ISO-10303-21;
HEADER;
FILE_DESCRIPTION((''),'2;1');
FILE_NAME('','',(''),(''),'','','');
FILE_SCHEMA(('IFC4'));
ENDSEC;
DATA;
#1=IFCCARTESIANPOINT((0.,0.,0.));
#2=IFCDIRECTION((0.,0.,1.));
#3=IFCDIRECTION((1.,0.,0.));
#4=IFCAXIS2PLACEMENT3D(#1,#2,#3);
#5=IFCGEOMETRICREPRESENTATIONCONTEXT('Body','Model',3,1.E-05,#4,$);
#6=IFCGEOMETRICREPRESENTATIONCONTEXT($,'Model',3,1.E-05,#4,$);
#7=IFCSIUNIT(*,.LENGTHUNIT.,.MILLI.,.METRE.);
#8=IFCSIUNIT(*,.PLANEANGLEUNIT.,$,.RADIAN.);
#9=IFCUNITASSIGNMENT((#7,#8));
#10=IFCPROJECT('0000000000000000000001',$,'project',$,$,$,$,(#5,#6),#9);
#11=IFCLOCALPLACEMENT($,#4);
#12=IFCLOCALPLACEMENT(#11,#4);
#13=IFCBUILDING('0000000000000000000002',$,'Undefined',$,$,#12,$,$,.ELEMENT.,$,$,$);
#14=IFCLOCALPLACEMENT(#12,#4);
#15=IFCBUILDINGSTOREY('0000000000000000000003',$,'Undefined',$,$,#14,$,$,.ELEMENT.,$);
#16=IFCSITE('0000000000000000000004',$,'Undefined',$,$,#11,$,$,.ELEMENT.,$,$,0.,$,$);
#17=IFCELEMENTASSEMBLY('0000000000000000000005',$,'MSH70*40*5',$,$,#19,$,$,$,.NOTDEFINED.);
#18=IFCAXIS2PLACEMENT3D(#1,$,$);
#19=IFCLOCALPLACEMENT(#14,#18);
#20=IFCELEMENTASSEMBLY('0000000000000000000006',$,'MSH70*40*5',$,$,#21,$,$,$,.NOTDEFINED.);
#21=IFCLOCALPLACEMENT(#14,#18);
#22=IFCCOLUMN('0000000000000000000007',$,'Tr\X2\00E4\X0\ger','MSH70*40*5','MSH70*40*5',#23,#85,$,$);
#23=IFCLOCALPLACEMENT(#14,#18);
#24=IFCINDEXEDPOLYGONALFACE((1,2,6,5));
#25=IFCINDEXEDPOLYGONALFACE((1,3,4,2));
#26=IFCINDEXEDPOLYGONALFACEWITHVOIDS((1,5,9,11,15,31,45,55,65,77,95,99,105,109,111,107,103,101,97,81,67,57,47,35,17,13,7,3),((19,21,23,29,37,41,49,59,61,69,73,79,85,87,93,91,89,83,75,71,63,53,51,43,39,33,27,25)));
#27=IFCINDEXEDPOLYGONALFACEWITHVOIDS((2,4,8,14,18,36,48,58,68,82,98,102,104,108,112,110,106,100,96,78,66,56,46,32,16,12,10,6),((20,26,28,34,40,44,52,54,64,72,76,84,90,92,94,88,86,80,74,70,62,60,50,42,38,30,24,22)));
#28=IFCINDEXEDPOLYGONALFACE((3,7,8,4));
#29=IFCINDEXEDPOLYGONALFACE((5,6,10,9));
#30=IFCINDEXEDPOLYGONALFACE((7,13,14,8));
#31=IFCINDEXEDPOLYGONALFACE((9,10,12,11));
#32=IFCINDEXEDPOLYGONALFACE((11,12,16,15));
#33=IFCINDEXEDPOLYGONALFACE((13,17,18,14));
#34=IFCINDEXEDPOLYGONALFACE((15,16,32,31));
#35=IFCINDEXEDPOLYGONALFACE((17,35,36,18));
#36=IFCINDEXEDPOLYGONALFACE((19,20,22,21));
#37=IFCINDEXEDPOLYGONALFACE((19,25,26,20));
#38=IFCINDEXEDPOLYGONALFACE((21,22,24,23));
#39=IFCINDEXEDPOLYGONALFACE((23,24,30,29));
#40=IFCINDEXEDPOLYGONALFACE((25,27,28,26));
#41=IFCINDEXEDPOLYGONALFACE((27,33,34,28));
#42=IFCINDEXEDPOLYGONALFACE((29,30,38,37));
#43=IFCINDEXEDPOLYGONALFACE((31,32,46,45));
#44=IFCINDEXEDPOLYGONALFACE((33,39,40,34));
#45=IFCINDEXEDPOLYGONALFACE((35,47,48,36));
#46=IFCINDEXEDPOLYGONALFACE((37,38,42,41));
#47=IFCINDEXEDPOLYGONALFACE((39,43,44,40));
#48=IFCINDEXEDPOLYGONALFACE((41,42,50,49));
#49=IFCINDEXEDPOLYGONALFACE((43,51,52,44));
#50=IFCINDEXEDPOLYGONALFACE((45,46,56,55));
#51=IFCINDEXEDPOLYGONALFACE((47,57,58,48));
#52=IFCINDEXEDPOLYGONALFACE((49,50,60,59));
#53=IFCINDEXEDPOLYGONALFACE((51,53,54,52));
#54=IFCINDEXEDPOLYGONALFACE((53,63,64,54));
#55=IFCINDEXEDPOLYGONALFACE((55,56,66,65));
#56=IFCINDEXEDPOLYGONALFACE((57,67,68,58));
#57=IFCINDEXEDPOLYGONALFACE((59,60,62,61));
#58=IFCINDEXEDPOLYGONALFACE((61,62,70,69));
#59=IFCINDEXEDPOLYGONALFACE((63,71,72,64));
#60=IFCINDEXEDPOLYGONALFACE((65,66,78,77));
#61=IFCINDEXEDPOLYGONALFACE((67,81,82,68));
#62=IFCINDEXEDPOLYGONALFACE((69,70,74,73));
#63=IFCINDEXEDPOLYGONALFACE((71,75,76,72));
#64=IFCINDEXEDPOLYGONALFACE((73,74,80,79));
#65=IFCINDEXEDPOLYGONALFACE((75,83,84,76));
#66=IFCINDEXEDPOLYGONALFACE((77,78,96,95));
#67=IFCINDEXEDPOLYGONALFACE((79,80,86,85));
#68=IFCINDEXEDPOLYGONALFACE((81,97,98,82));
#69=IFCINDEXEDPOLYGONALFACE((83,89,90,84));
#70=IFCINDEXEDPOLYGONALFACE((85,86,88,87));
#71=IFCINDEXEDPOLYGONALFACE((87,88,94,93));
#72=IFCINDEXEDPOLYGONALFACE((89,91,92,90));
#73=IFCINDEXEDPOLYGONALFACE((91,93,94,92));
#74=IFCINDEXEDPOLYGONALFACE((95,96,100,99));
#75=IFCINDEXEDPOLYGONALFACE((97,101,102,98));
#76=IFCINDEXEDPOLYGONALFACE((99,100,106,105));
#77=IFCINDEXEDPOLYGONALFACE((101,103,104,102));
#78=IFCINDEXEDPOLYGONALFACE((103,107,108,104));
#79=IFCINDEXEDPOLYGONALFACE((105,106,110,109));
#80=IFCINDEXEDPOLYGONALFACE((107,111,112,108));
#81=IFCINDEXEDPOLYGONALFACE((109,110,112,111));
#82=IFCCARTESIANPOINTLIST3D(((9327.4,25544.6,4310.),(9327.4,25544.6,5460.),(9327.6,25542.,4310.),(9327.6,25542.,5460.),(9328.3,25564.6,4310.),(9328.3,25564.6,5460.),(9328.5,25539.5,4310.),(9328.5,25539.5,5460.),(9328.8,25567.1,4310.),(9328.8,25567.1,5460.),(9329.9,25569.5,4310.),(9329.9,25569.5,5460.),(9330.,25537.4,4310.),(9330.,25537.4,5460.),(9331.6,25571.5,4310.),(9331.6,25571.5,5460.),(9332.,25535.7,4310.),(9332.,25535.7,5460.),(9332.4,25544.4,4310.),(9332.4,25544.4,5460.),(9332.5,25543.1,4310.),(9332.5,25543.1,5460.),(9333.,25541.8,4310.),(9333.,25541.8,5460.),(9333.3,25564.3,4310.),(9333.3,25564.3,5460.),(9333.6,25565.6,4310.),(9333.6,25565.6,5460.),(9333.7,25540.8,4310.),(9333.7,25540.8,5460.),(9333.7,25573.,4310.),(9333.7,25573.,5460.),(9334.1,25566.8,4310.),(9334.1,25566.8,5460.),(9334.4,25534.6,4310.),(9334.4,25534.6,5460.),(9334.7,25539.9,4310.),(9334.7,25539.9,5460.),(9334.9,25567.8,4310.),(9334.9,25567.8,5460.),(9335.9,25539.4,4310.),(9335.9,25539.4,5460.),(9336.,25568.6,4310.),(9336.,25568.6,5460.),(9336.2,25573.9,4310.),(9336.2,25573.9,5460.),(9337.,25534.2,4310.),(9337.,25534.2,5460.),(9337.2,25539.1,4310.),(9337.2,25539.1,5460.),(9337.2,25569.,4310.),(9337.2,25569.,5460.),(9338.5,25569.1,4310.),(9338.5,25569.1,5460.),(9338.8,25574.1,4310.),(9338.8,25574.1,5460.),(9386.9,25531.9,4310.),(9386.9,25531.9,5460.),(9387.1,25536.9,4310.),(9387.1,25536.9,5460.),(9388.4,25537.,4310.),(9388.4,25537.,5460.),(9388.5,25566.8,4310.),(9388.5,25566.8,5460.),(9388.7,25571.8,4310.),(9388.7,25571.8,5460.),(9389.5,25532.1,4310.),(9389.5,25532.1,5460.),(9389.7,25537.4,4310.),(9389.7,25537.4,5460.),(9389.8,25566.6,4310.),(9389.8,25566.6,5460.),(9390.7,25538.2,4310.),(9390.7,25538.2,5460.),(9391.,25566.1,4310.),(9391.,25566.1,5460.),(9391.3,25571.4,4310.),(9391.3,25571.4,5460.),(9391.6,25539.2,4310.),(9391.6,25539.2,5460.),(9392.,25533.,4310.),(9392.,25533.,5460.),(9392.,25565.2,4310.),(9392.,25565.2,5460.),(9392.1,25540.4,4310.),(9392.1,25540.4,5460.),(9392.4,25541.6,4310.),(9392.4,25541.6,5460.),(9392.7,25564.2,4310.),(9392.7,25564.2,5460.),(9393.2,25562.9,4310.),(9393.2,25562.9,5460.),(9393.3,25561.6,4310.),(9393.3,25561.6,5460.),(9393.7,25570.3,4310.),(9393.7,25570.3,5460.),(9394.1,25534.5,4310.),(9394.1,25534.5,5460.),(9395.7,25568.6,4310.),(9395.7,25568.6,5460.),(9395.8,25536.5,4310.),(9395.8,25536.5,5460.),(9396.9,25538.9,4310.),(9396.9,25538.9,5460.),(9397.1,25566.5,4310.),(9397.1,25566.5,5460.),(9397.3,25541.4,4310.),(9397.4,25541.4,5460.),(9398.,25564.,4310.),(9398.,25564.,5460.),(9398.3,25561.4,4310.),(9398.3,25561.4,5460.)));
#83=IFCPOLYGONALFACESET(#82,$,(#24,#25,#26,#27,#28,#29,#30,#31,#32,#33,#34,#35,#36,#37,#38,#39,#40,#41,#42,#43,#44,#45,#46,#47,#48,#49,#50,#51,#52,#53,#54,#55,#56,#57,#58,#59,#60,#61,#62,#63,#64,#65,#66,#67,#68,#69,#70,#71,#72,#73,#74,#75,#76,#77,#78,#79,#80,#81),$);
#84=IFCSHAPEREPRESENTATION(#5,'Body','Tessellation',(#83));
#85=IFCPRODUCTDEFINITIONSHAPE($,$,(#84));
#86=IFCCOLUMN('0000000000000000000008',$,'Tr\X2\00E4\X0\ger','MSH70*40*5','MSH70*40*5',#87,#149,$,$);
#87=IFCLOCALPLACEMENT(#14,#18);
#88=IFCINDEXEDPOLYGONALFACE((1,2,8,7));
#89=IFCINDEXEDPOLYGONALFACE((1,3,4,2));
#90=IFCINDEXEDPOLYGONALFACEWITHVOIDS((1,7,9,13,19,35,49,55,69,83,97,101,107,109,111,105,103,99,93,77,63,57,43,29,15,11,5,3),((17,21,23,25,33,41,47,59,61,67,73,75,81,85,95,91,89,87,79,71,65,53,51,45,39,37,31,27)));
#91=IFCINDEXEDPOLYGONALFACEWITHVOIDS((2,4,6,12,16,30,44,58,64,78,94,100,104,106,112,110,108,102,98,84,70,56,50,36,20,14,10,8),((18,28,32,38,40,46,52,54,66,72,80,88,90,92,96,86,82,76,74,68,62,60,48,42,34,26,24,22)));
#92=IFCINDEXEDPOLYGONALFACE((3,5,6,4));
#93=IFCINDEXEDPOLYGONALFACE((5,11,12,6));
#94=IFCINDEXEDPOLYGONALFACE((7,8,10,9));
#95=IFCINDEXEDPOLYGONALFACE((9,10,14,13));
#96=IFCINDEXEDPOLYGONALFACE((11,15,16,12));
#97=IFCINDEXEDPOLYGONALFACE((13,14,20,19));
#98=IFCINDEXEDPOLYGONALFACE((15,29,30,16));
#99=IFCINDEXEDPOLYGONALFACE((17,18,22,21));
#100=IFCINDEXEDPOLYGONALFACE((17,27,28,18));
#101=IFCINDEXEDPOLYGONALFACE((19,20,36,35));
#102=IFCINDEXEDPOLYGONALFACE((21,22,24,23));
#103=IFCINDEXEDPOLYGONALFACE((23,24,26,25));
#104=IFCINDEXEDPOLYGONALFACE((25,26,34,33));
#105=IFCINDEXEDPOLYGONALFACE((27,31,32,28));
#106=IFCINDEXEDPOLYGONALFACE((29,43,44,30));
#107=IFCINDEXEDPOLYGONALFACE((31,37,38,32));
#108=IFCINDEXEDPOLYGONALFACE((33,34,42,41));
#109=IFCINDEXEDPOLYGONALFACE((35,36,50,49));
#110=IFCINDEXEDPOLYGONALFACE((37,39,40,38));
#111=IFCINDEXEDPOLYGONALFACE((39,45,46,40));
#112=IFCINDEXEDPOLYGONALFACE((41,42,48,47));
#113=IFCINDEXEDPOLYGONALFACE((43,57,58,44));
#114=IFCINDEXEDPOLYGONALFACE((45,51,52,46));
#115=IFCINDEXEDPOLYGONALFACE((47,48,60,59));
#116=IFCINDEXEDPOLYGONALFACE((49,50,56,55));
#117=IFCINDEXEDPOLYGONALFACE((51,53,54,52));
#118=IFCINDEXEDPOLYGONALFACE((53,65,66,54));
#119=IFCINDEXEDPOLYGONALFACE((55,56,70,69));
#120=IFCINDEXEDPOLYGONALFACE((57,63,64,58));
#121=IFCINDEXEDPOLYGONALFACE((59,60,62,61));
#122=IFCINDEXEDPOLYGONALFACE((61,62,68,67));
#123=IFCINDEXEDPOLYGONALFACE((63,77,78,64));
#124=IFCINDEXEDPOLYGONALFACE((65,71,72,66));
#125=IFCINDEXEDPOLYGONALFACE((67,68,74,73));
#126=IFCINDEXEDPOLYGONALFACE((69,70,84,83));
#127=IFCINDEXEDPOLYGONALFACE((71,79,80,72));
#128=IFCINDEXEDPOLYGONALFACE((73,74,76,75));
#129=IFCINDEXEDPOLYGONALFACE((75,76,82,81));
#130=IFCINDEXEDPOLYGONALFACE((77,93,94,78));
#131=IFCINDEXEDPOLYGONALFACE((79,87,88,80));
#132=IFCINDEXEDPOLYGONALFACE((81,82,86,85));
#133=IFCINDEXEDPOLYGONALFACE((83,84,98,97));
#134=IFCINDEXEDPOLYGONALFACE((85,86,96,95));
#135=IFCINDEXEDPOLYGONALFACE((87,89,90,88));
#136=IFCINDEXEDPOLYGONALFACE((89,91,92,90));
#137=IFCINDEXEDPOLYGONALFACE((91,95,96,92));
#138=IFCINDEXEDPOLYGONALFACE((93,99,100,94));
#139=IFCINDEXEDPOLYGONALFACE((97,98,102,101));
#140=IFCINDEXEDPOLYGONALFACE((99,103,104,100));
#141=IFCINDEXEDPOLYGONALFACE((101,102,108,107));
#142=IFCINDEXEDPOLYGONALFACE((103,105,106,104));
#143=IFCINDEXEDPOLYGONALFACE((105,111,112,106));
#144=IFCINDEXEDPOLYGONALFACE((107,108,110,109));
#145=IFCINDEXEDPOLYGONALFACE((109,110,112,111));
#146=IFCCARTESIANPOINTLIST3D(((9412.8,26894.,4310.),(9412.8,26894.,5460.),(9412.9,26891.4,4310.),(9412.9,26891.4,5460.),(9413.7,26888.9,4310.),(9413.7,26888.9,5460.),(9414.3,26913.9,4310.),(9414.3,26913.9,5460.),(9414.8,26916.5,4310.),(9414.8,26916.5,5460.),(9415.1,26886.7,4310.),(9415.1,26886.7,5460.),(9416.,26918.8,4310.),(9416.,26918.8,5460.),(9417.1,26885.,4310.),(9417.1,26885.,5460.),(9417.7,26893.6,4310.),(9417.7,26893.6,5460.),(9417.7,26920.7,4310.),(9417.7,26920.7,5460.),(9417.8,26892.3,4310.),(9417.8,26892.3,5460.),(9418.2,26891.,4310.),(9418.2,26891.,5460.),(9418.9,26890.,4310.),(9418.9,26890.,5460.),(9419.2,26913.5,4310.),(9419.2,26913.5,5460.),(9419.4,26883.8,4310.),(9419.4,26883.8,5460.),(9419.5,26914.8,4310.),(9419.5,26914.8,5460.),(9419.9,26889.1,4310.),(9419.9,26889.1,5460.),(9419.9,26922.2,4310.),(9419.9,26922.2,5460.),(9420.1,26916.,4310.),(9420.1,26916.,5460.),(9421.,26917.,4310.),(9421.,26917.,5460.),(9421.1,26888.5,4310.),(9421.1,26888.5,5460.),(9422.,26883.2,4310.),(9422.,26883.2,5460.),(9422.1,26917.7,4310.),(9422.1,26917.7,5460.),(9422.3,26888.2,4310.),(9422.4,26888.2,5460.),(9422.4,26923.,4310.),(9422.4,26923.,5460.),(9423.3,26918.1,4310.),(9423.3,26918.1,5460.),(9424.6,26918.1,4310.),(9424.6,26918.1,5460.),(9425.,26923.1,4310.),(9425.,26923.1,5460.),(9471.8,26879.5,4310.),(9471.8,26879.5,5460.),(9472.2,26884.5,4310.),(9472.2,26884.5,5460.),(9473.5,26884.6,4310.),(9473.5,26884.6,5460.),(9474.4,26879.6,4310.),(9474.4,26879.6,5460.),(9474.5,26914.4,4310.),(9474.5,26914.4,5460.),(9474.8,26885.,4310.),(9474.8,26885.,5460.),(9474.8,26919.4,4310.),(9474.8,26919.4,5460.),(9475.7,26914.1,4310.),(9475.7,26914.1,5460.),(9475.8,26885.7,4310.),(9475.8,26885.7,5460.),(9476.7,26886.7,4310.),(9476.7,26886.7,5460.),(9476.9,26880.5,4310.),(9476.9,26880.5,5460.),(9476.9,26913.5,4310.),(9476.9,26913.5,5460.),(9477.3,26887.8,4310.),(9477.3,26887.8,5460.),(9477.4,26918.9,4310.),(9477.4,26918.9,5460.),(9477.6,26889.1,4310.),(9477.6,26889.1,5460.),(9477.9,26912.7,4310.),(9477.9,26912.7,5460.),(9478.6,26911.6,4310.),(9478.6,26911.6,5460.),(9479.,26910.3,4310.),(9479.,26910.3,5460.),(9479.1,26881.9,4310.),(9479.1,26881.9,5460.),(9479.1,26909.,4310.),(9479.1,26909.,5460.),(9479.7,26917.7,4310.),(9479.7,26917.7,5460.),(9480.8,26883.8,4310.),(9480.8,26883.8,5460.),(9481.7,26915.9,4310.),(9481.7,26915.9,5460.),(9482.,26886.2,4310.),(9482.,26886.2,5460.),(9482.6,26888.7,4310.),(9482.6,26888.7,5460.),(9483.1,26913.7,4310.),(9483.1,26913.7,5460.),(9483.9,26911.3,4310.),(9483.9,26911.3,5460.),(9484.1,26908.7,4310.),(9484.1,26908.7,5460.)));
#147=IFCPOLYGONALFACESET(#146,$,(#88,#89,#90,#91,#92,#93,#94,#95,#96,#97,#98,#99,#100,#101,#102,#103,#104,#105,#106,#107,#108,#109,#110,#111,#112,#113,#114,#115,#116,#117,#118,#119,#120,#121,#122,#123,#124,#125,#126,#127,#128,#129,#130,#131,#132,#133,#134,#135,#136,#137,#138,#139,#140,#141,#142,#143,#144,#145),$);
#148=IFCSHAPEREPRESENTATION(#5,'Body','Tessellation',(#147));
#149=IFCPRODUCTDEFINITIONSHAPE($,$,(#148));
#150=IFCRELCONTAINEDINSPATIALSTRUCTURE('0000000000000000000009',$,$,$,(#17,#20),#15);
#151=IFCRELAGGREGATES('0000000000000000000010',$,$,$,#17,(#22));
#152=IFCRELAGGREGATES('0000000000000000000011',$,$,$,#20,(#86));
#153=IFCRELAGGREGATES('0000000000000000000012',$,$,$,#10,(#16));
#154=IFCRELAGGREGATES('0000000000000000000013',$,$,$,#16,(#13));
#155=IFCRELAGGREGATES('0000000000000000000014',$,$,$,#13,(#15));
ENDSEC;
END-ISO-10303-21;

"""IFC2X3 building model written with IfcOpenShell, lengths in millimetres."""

from ifc_helpers import new_model, si_unit, frame, origin_with_axes, origin_2d_with_axis, place, context, project, spatial, hollow_rectangle, extrude, element, aggregate, save


model = new_model("IFC2X3")

# Units and contexts
model_context_1 = context("Model", 3, precision=1e-05, world=origin_with_axes(), identifier="Body")
model_context_2 = context("Model", 3, precision=1e-05, world=origin_with_axes())
ifc_project = project(units=[si_unit("LENGTHUNIT", "METRE", prefix="MILLI"), si_unit("PLANEANGLEUNIT", "RADIAN")], contexts=[model_context_1, model_context_2])

# Site, building, storey
site_placement = place(None, origin_with_axes())
site = spatial("IfcSite", under=ifc_project, at=site_placement, Name="Undefined", CompositionType="ELEMENT", RefElevation=0.0)
building_placement = place(site_placement, origin_with_axes())
building = spatial("IfcBuilding", under=site, at=building_placement, Name="Undefined", CompositionType="ELEMENT")
storey_placement = place(building_placement, origin_with_axes())
storey = spatial("IfcBuildingStorey", under=building, at=storey_placement, Name="Undefined", CompositionType="ELEMENT")

# Element assembly
assembly_1 = element("IfcElementAssembly", 1, inside=storey, Name="MSH70*40*5", PredefinedType="NOTDEFINED")

# Element assembly
assembly_2 = element("IfcElementAssembly", 2, inside=storey, Name="MSH70*40*5", PredefinedType="NOTDEFINED")

# Columns
column_1_placement = place(storey_placement, frame((9362.8, 25553.0, 4310.0), z_axis=(0.0, 0.0, 1.0), x_axis=(1.0, 0.0, 0.0)))
column_1 = element("IfcColumn", 3, at=column_1_placement, Name="Träger", Description="MSH70*40*5", ObjectType="MSH70*40*5", context=model_context_1, shape_type="SweptSolid", body=[
    extrude(hollow_rectangle(XDim=40.0, YDim=70.0, WallThickness=5.0, InnerFilletRadius=5.0, OuterFilletRadius=10.0, at=origin_2d_with_axis()), frame((0.0, 0.0, 1150.0), z_axis=(0.0, 0.0, -1.0), x_axis=(-0.045363, -0.998971, 0.0)), (0.0, 0.0, 1.0), 1150.0),
])
aggregate(assembly_1, [column_1])
column_2_placement = place(storey_placement, frame((9448.4, 26901.3, 4310.0), z_axis=(0.0, 0.0, 1.0), x_axis=(1.0, 0.0, 0.0)))
column_2 = element("IfcColumn", 4, at=column_2_placement, Name="Träger", Description="MSH70*40*5", ObjectType="MSH70*40*5", context=model_context_1, shape_type="SweptSolid", body=[
    extrude(hollow_rectangle(XDim=40.0, YDim=70.0, WallThickness=5.0, InnerFilletRadius=5.0, OuterFilletRadius=10.0, at=origin_2d_with_axis()), frame((0.0, 0.0, 1150.0), z_axis=(0.0, 0.0, -1.0), x_axis=(-0.074979, -0.997185, 0.0)), (0.0, 0.0, 1.0), 1150.0),
])
aggregate(assembly_2, [column_2])

save(model, "model.ifc")
